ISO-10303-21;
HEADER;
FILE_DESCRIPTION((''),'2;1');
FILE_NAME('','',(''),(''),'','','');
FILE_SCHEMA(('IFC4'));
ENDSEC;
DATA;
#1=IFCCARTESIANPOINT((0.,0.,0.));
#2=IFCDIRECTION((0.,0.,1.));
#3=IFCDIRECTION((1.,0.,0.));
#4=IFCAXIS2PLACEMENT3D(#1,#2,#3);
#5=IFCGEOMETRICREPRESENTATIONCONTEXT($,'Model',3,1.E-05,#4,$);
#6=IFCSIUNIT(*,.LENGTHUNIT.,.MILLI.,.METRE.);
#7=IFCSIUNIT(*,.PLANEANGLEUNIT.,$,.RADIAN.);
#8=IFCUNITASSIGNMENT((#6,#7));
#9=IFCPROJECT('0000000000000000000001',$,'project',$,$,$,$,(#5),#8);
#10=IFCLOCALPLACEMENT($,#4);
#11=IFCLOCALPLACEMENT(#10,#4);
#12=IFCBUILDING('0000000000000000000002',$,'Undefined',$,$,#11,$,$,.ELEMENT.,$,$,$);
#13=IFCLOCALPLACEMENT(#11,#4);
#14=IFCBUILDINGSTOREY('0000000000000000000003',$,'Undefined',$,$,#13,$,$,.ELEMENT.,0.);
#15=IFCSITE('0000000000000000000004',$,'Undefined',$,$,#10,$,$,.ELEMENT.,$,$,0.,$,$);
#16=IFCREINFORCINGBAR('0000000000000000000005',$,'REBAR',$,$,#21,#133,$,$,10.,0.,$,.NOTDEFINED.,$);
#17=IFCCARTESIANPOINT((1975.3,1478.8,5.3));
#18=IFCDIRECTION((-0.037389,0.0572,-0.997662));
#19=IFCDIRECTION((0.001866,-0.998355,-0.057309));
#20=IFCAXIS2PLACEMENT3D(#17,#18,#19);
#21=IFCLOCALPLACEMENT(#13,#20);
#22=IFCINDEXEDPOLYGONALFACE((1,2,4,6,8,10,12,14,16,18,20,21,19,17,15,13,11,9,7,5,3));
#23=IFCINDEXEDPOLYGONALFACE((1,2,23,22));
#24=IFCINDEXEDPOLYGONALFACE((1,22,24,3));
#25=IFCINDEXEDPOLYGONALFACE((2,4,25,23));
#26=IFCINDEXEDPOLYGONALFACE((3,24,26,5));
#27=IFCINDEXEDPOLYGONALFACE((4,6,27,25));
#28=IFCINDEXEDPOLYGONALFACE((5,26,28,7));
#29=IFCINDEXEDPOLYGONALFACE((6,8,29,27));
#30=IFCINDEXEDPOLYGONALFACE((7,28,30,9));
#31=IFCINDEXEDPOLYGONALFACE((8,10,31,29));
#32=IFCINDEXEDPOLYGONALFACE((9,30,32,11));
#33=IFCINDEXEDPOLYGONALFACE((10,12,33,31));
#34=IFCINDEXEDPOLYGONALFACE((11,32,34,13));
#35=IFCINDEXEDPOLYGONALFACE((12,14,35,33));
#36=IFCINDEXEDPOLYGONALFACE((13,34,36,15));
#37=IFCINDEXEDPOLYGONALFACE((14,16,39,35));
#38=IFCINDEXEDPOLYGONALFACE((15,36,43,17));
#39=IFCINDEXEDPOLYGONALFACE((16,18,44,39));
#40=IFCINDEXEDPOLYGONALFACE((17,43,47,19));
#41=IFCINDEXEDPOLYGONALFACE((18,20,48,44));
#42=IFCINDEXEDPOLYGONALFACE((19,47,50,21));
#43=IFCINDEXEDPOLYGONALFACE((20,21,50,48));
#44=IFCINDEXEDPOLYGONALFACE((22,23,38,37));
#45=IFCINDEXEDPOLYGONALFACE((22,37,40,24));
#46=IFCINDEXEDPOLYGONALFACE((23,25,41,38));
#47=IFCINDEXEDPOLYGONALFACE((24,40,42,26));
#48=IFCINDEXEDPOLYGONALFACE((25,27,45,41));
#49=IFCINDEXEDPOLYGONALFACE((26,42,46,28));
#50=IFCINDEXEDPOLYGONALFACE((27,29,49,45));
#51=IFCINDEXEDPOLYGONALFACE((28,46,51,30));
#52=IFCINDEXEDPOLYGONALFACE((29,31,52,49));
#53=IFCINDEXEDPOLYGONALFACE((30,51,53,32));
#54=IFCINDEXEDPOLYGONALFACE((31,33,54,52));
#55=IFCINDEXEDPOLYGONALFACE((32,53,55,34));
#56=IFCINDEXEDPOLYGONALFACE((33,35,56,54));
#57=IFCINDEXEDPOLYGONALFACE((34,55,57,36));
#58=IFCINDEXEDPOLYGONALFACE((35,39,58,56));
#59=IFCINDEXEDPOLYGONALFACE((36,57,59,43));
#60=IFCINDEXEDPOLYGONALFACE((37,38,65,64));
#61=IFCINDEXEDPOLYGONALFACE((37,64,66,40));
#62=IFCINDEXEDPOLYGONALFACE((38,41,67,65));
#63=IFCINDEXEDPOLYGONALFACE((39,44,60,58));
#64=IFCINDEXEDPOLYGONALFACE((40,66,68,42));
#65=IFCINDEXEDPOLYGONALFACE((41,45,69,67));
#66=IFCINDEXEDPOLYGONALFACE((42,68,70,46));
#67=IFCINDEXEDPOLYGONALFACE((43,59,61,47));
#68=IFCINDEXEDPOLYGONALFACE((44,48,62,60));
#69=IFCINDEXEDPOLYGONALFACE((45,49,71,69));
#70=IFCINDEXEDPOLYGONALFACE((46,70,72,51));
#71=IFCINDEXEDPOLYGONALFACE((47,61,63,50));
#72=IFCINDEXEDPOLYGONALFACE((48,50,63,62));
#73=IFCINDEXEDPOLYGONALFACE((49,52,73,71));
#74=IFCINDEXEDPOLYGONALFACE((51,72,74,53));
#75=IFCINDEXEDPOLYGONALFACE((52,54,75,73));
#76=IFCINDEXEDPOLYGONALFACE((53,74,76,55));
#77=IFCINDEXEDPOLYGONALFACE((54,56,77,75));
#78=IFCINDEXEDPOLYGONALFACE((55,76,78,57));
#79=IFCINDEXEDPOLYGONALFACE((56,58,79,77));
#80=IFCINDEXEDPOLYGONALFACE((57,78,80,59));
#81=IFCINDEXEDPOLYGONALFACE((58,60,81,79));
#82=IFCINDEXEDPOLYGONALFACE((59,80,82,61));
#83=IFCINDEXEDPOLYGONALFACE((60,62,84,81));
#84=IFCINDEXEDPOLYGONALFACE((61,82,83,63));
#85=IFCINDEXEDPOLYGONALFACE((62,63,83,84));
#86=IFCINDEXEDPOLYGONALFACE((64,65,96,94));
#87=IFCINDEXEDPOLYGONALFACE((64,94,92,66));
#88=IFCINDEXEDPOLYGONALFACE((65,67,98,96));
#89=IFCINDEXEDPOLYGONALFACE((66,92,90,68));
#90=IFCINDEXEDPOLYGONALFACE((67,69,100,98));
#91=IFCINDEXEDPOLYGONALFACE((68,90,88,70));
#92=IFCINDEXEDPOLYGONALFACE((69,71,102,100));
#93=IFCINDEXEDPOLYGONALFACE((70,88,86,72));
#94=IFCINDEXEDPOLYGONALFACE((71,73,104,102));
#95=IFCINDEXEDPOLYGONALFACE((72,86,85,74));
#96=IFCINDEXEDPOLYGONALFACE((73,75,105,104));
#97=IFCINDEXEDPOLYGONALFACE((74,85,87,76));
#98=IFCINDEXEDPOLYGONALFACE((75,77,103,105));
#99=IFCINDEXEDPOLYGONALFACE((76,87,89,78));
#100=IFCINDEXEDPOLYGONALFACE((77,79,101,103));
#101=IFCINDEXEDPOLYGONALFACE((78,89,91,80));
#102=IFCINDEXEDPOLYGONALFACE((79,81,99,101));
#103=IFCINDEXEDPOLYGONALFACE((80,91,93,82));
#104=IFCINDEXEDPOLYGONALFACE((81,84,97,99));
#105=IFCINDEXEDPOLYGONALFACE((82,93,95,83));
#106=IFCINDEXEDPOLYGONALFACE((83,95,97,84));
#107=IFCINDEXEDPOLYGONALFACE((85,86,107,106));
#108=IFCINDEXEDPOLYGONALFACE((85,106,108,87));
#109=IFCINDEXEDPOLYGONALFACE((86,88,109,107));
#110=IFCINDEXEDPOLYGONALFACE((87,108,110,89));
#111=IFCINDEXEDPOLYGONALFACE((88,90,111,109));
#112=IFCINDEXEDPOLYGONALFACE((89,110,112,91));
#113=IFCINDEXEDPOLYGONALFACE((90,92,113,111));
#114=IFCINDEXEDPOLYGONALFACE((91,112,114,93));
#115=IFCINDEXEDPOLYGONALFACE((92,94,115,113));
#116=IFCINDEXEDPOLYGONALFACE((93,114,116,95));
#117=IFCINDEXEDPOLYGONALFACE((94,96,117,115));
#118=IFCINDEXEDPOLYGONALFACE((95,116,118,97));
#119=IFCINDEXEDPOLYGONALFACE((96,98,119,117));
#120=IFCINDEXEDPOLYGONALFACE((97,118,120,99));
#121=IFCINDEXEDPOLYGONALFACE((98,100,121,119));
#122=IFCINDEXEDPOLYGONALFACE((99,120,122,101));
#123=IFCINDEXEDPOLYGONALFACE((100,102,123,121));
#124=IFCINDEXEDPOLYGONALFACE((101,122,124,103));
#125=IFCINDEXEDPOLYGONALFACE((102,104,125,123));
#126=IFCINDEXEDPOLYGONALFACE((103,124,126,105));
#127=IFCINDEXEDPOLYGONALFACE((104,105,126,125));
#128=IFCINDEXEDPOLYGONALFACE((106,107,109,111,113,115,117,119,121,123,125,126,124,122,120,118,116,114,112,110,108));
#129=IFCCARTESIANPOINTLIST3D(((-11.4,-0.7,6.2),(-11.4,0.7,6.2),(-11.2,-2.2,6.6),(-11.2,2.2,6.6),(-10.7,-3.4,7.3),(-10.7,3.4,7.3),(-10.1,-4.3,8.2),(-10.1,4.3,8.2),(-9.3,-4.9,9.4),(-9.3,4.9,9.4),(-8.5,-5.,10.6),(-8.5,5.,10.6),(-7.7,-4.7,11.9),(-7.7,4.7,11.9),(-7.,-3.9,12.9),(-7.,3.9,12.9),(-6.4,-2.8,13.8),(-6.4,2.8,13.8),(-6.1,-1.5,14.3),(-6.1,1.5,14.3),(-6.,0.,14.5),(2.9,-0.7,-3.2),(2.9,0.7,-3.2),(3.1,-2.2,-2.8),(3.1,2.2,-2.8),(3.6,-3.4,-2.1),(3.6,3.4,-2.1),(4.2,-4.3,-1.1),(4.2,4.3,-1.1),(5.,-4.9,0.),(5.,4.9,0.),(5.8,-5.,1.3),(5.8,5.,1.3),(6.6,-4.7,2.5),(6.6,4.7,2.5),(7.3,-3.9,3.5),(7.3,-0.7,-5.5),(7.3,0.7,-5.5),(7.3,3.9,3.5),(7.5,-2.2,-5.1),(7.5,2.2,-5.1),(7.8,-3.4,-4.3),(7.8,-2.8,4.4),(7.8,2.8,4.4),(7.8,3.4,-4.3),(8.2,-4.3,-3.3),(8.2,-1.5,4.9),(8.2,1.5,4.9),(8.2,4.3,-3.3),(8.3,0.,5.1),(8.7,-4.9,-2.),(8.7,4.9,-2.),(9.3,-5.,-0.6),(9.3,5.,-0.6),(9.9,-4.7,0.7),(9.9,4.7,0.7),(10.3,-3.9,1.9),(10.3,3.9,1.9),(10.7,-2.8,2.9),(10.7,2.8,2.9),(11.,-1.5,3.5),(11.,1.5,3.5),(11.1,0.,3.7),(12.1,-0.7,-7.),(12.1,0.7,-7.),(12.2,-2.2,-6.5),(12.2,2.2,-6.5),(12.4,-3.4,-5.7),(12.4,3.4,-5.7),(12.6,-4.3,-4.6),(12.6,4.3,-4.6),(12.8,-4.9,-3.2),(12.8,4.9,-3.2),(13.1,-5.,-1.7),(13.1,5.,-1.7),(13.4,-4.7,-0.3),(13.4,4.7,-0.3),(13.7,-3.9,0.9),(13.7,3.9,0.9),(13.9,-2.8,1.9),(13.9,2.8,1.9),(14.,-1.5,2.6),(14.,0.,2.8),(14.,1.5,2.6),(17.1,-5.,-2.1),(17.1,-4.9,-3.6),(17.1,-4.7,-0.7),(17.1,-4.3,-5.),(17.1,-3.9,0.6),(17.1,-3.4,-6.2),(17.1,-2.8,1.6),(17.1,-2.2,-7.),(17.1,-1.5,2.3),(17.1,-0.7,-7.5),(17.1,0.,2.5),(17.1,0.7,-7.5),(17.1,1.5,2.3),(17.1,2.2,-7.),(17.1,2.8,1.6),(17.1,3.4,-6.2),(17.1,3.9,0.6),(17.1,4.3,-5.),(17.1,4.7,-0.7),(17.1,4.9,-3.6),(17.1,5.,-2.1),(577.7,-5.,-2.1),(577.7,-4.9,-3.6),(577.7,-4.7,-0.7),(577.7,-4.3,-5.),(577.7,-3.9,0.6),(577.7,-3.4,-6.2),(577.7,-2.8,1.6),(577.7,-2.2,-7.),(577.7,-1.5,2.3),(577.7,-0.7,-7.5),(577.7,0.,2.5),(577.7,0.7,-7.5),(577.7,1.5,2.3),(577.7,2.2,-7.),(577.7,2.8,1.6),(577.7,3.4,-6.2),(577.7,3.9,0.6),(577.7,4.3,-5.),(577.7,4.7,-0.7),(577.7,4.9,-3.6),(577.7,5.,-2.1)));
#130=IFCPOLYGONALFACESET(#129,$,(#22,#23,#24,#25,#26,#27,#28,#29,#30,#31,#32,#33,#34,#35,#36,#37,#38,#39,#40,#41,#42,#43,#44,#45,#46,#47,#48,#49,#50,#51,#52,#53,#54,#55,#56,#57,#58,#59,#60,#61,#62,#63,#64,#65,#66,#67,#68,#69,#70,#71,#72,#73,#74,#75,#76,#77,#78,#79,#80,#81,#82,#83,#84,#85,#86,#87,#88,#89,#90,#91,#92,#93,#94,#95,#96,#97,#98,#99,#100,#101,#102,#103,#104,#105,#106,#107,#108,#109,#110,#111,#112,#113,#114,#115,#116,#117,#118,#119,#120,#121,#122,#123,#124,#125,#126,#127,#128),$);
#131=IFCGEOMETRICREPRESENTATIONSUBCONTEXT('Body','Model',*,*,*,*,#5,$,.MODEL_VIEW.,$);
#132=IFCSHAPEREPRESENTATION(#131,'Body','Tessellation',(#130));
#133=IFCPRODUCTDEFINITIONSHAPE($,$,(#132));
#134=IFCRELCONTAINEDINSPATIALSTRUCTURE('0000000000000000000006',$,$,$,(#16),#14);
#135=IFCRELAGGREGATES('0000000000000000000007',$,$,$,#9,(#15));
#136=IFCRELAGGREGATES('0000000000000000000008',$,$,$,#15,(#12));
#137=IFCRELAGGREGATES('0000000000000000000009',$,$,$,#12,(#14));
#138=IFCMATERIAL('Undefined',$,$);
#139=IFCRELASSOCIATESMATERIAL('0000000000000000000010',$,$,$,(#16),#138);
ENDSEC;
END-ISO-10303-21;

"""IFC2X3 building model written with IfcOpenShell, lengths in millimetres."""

from ifc_helpers import new_model, entity, si_unit, frame, origin_with_axes, place, context, subcontext, project, spatial, source, transform, mapped, material, element, save


model = new_model("IFC2X3")

# Units and contexts
model_context = context("Model", 3, precision=1e-05, world=origin_with_axes())
body_context = subcontext(model_context, "Body", "Model", "MODEL_VIEW")
ifc_project = project(units=[si_unit("LENGTHUNIT", "METRE", prefix="MILLI"), si_unit("PLANEANGLEUNIT", "RADIAN")], contexts=[model_context])

# Site, building, storey
site_placement = place(None, origin_with_axes())
site = spatial("IfcSite", under=ifc_project, at=site_placement, Name="Undefined", CompositionType="ELEMENT", RefElevation=0.0)
building_placement = place(site_placement, origin_with_axes())
building = spatial("IfcBuilding", under=site, at=building_placement, Name="Undefined", CompositionType="ELEMENT")
storey_placement = place(building_placement, origin_with_axes())
storey = spatial("IfcBuildingStorey", under=building, at=storey_placement, Name="Undefined", CompositionType="ELEMENT", Elevation=0.0)

# Reinforcing bar
ifc_material_1 = material(Name="Undefined")
shared_shape_1 = source(origin_with_axes(), body_context, "Body", "AdvancedSweptSolid", [
    entity("IfcSweptDiskSolid", entity("IfcCompositeCurve", [entity("IfcCompositeCurveSegment", "CONTINUOUS", True, entity("IfcTrimmedCurve", entity("IfcLine", entity("IfcCartesianPoint", [0.0, 0.0, 0.0]), entity("IfcVector", entity("IfcDirection", [0.835483, 0.0, -0.549516]), 1.0)), [entity("IfcParameterValue", 0.0)], [entity("IfcParameterValue", 17.082101)], True, "PARAMETER")), entity("IfcCompositeCurveSegment", "CONTINUOUS", True, entity("IfcTrimmedCurve", entity("IfcCircle", entity("IfcAxis2Placement3D", entity("IfcCartesianPoint", [25.8, 0.0, 8.2]), entity("IfcDirection", [0.0, -1.0, 0.0]), entity("IfcDirection", [-0.549516, 0.0, -0.835483])), 21.0), [entity("IfcParameterValue", 0.0)], [entity("IfcParameterValue", 0.581785)], True, "PARAMETER")), entity("IfcCompositeCurveSegment", "DISCONTINUOUS", True, entity("IfcTrimmedCurve", entity("IfcLine", entity("IfcCartesianPoint", [25.8, 0.0, -12.8]), entity("IfcVector", entity("IfcDirection", [1.0, 0.0, 0.0]), 1.0)), [entity("IfcParameterValue", 0.0)], [entity("IfcParameterValue", 560.593055)], True, "PARAMETER"))], False), 5.0, None, 0.0, 578.3),
])
reinforcing_bar_1_placement = place(storey_placement, frame((1975.3, 1478.8, 5.3), z_axis=(-0.037389, 0.0572, -0.997662), x_axis=(0.001866, -0.998355, -0.057309)))
element("IfcReinforcingBar", 1, at=reinforcing_bar_1_placement, inside=storey, material=ifc_material_1, Name="REBAR", BarRole="NOTDEFINED", CrossSectionArea=0.0, NominalDiameter=10.0, context=body_context, shape_type="MappedRepresentation", body=[
    mapped(shared_shape_1, transform((-8.7, 0.0, 10.3))),
])

save(model, "model.ifc")
